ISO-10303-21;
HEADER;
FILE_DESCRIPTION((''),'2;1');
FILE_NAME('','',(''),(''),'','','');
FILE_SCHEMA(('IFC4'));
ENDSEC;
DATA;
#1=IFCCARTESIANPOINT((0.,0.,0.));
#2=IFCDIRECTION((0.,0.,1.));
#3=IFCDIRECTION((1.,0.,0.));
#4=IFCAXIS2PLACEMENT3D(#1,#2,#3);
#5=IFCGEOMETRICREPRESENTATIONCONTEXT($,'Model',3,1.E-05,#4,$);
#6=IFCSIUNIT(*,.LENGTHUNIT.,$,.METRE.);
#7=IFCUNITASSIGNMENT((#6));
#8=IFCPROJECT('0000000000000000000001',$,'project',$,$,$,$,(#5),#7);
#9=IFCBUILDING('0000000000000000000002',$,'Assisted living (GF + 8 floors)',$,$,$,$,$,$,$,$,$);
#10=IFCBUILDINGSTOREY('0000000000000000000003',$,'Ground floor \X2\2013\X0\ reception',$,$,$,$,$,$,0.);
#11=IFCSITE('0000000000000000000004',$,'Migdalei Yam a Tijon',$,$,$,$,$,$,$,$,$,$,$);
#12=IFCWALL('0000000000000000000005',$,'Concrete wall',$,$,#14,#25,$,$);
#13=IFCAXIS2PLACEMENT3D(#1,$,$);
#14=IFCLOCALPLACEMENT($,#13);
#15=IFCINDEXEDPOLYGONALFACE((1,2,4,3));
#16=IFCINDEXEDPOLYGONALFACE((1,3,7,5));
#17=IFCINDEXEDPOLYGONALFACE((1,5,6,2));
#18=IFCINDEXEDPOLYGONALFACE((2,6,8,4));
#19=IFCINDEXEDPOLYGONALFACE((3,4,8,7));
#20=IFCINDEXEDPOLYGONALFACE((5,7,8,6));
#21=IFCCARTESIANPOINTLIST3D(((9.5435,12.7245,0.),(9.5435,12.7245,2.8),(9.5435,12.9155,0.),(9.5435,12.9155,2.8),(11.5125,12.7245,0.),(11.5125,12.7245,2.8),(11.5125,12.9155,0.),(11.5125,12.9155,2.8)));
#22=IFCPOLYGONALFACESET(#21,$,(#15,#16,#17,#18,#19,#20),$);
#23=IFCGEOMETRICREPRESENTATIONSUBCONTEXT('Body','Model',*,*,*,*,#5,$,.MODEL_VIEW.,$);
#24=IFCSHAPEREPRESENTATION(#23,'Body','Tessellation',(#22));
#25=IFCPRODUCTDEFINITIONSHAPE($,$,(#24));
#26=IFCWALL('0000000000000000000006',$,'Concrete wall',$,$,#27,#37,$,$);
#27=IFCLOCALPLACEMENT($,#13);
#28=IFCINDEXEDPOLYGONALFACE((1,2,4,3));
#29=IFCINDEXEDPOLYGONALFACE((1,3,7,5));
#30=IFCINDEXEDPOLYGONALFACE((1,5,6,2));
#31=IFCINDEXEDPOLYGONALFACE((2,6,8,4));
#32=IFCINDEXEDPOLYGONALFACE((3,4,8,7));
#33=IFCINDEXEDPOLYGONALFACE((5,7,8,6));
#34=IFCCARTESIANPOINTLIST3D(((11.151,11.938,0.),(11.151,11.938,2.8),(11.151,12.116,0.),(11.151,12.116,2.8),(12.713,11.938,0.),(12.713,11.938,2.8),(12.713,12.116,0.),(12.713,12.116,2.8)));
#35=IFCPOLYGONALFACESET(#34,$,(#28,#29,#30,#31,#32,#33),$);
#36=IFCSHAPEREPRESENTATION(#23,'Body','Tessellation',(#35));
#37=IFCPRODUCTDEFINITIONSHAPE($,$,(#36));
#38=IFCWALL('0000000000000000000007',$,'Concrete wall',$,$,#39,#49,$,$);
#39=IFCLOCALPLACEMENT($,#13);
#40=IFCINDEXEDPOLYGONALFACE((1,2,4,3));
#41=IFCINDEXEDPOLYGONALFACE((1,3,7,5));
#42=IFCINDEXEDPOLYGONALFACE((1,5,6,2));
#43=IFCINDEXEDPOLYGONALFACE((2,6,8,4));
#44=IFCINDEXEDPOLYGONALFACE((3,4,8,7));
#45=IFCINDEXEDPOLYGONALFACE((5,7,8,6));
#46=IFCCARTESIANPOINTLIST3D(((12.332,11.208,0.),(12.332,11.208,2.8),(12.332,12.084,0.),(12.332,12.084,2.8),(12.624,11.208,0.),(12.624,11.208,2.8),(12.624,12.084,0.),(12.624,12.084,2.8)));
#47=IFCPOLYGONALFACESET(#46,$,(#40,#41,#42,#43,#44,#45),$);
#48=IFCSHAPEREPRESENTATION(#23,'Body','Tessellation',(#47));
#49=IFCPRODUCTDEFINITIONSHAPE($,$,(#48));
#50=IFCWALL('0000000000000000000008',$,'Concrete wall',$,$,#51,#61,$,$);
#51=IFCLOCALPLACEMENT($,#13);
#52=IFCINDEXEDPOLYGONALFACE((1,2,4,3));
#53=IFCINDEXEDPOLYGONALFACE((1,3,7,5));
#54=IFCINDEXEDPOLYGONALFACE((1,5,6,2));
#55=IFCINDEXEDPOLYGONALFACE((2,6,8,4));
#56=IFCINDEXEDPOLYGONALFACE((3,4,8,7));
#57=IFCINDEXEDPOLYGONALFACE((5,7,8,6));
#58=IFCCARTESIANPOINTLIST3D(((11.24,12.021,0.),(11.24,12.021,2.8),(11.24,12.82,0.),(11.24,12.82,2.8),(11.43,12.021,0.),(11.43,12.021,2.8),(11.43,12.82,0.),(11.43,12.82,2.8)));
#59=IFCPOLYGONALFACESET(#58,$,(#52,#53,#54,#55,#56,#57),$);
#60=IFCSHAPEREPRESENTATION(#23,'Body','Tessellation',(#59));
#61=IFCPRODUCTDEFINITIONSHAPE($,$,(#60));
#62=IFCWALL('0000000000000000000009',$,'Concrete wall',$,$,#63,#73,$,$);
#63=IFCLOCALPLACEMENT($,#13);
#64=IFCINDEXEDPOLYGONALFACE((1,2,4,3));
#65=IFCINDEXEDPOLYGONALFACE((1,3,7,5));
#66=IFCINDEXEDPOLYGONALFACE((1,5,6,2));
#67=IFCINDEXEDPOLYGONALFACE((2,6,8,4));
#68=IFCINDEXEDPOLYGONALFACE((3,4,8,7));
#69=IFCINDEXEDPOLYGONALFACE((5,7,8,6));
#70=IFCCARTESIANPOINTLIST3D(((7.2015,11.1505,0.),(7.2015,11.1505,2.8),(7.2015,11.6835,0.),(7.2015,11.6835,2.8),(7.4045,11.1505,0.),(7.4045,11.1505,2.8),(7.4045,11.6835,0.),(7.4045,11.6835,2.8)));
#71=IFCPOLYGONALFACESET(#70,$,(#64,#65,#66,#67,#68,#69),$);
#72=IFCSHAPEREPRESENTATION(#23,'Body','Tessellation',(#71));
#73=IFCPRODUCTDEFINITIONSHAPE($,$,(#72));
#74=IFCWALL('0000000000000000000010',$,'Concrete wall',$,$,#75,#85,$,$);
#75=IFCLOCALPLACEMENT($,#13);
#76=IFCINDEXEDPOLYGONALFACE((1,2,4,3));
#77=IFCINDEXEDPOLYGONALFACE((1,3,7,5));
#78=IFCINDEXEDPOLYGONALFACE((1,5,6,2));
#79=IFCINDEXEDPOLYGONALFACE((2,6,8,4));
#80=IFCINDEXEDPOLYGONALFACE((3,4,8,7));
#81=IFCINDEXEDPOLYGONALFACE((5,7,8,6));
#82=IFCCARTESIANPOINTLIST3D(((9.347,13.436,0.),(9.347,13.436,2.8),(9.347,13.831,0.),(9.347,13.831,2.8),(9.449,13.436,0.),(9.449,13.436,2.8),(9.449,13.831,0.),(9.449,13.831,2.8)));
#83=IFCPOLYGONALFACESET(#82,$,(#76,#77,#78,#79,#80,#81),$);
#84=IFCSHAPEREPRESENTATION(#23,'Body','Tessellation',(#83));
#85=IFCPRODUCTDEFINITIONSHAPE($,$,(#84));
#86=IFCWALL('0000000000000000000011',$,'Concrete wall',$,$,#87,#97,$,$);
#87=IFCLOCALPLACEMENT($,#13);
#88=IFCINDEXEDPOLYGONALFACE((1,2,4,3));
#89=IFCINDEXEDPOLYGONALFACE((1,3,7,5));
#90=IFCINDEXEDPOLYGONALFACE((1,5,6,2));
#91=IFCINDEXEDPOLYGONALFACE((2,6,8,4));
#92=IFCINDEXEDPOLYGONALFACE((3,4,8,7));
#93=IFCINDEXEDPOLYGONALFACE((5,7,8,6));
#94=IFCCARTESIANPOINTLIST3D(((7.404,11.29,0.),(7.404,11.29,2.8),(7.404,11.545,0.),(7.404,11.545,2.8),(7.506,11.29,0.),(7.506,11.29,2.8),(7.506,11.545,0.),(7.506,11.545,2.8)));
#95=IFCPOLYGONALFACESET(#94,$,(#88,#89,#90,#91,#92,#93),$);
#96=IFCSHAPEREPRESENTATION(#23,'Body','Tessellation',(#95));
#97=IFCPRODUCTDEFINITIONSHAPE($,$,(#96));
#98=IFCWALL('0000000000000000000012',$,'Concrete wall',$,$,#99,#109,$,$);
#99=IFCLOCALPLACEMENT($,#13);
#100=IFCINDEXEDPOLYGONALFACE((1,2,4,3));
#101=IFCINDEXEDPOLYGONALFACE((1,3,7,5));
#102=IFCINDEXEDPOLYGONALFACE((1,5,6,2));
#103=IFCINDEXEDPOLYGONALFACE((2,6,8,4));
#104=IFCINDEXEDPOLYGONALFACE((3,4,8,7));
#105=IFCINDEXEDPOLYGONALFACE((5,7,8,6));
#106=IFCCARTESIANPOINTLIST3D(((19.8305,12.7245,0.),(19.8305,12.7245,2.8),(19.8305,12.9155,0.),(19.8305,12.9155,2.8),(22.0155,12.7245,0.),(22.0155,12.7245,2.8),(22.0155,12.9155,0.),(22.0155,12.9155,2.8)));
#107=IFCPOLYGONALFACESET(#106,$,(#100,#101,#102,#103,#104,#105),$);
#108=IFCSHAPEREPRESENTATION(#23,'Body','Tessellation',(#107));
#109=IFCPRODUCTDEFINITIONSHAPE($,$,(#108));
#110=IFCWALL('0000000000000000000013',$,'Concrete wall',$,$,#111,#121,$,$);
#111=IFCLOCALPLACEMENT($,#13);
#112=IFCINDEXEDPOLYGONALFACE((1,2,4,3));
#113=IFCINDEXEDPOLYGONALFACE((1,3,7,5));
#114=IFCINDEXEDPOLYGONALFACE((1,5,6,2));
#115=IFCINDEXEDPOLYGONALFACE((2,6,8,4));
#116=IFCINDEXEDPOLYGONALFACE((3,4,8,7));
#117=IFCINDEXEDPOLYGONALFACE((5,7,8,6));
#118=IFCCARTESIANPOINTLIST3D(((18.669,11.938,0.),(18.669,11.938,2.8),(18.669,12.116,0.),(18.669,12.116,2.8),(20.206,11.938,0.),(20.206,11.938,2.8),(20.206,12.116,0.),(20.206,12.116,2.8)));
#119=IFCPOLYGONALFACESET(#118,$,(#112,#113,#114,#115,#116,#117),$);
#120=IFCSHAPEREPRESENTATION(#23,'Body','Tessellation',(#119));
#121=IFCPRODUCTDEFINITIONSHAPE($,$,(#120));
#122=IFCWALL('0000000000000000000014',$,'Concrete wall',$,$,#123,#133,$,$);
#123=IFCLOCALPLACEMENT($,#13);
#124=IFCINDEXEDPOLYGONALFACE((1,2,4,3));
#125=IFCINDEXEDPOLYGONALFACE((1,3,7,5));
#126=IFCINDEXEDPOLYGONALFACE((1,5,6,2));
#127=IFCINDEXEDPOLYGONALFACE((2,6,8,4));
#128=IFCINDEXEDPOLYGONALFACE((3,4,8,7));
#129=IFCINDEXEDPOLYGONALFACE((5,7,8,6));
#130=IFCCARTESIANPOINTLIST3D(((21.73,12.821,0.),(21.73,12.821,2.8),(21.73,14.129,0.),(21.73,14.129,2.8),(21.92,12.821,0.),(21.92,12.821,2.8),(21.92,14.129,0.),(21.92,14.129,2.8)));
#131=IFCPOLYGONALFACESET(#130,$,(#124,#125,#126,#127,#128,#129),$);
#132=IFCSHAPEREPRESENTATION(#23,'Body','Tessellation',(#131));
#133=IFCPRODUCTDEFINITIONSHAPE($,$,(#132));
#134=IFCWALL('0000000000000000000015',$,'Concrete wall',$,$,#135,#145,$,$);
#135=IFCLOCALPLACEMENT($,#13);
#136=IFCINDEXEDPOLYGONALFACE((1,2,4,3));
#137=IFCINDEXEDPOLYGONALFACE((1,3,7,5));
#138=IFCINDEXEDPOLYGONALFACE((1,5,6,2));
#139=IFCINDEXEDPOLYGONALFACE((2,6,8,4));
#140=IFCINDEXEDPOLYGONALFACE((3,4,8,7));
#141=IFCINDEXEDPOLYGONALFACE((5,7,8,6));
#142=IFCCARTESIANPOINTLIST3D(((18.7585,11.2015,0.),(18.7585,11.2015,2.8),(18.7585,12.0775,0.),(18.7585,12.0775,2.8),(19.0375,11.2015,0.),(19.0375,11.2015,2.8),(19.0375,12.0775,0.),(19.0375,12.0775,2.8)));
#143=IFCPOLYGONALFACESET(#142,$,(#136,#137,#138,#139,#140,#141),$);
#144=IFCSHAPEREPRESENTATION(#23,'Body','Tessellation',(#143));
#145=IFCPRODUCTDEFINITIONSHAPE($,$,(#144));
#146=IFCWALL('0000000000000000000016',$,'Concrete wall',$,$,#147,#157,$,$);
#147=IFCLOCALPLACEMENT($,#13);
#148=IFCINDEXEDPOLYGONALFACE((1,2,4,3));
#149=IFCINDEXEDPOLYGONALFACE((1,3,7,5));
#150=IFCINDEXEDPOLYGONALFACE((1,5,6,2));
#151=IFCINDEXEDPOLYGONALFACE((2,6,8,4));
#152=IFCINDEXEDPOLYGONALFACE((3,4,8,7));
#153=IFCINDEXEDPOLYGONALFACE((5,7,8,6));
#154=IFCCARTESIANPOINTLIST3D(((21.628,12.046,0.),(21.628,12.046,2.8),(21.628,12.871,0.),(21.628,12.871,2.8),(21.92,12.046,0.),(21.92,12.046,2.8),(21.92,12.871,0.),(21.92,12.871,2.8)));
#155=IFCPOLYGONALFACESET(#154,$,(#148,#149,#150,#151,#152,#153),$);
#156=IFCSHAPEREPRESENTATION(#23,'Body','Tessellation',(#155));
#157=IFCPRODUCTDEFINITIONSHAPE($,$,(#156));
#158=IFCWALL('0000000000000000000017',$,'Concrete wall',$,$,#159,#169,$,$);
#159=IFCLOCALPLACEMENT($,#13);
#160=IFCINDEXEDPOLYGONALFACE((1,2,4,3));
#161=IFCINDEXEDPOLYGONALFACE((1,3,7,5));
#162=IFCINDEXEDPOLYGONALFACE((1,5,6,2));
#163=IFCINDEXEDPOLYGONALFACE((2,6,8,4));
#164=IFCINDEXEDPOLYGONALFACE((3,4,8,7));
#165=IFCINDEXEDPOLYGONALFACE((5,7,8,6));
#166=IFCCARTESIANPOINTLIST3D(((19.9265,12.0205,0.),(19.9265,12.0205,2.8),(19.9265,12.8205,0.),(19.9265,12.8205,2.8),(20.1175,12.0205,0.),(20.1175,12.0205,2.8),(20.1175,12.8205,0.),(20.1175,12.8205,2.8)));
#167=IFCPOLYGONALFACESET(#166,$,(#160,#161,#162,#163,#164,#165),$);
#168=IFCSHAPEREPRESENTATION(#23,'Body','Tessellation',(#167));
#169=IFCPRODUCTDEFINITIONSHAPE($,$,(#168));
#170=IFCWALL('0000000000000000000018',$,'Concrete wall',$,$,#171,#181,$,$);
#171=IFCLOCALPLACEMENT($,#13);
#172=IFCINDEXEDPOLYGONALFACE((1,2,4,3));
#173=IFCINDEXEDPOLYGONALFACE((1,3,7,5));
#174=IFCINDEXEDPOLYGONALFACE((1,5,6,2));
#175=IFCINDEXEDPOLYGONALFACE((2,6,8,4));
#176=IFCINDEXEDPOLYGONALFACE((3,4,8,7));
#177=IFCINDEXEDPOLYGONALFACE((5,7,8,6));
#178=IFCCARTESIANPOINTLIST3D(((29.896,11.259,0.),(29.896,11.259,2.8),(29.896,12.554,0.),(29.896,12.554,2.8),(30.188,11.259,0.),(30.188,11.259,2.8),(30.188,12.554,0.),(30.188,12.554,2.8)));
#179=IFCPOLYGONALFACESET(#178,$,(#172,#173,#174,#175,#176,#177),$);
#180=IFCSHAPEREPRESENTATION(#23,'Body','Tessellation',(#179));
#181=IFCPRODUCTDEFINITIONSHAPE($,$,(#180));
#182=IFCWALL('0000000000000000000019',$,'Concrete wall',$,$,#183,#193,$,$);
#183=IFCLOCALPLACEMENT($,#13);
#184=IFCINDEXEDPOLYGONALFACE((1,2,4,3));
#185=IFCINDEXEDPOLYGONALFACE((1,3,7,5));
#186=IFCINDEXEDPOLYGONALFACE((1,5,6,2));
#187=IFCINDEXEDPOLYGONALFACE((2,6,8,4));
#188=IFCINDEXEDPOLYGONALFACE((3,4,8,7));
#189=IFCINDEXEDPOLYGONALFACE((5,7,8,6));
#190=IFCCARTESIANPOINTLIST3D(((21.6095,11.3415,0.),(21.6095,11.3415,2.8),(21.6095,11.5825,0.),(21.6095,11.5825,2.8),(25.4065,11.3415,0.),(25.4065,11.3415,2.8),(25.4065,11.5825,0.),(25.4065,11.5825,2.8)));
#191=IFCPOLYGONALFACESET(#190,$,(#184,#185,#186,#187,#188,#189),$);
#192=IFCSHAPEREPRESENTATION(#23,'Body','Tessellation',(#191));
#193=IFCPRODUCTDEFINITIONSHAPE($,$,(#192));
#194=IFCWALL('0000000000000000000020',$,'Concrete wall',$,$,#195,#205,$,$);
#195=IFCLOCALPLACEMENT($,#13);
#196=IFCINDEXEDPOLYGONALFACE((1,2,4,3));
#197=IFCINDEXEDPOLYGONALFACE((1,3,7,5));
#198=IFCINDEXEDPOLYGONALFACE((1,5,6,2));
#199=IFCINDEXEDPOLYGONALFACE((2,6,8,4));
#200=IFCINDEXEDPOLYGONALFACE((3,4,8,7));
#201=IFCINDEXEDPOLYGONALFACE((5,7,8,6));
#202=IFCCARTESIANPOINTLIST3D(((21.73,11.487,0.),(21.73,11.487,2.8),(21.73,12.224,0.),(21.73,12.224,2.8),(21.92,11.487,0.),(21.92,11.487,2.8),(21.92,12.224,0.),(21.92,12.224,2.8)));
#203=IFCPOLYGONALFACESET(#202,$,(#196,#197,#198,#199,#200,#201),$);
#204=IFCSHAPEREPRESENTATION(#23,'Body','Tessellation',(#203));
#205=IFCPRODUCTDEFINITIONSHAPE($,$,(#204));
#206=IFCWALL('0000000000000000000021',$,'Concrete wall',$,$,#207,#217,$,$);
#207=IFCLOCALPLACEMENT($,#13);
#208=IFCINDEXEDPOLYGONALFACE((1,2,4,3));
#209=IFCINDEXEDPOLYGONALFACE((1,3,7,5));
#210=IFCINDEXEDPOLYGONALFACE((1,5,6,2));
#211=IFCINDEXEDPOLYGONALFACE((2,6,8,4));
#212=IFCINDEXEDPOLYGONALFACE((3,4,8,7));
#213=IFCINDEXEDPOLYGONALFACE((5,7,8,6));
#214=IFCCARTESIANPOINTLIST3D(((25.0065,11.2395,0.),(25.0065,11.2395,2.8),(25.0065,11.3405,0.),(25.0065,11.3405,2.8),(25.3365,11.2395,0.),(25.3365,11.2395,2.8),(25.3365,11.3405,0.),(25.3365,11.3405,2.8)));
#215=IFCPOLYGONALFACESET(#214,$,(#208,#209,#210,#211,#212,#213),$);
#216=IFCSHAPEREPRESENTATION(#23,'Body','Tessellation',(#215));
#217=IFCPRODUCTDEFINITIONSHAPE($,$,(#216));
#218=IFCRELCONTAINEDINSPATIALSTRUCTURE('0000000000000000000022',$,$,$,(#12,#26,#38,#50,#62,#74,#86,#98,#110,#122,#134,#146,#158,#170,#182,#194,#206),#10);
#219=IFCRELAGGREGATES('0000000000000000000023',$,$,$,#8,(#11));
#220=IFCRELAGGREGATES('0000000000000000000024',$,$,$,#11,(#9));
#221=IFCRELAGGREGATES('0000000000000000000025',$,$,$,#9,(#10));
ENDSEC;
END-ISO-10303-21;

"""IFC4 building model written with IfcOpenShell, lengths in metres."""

from ifc_helpers import new_model, si_unit, frame, origin_with_axes, context, subcontext, project, spatial, line, indexed_curve, outline, extrude, element, save


model = new_model("IFC4")

# Units and contexts
model_context = context("Model", 3, precision=1e-05, world=origin_with_axes())
body_context = subcontext(model_context, "Body", "Model", "MODEL_VIEW")
ifc_project = project(units=[si_unit("LENGTHUNIT", "METRE")], contexts=[model_context])

# Site, building, storey
site = spatial("IfcSite", under=ifc_project, Name="Migdalei Yam a Tijon")
building = spatial("IfcBuilding", under=site, Name="Assisted living (GF + 8 floors)")
storey = spatial("IfcBuildingStorey", under=building, Name="Ground floor – reception", Elevation=0.0)

# Walls
element("IfcWall", 1, inside=storey, Name="Concrete wall", context=body_context, shape_type="SweptSolid", body=[
    extrude(outline(indexed_curve([(0.0, 0.0), (1.969, 0.0), (1.969, 0.191), (0.0, 0.191)], segments=[line(1, 2, 3, 4, 1)])), frame((9.5435, 12.7245, 0.0), z_axis=(0.0, 0.0, 1.0), x_axis=(1.0, 0.0, 0.0)), (0.0, 0.0, 1.0), 2.8),
])
element("IfcWall", 2, inside=storey, Name="Concrete wall", context=body_context, shape_type="SweptSolid", body=[
    extrude(outline(indexed_curve([(0.0, 0.0), (1.562, 0.0), (1.562, 0.178), (0.0, 0.178)], segments=[line(1, 2, 3, 4, 1)])), frame((11.151, 11.938, 0.0), z_axis=(0.0, 0.0, 1.0), x_axis=(1.0, 0.0, 0.0)), (0.0, 0.0, 1.0), 2.8),
])
element("IfcWall", 3, inside=storey, Name="Concrete wall", context=body_context, shape_type="SweptSolid", body=[
    extrude(outline(indexed_curve([(0.0, 0.0), (0.292, 0.0), (0.292, 0.876), (0.0, 0.876)], segments=[line(1, 2, 3, 4, 1)])), frame((12.332, 11.208, 0.0), z_axis=(0.0, 0.0, 1.0), x_axis=(1.0, 0.0, 0.0)), (0.0, 0.0, 1.0), 2.8),
])
element("IfcWall", 4, inside=storey, Name="Concrete wall", context=body_context, shape_type="SweptSolid", body=[
    extrude(outline(indexed_curve([(0.0, 0.0), (0.19, 0.0), (0.19, 0.799), (0.0, 0.799)], segments=[line(1, 2, 3, 4, 1)])), frame((11.24, 12.021, 0.0), z_axis=(0.0, 0.0, 1.0), x_axis=(1.0, 0.0, 0.0)), (0.0, 0.0, 1.0), 2.8),
])
element("IfcWall", 5, inside=storey, Name="Concrete wall", context=body_context, shape_type="SweptSolid", body=[
    extrude(outline(indexed_curve([(0.0, 0.0), (0.203, 0.0), (0.203, 0.533), (0.0, 0.533)], segments=[line(1, 2, 3, 4, 1)])), frame((7.2015, 11.1505, 0.0), z_axis=(0.0, 0.0, 1.0), x_axis=(1.0, 0.0, 0.0)), (0.0, 0.0, 1.0), 2.8),
])
element("IfcWall", 6, inside=storey, Name="Concrete wall", context=body_context, shape_type="SweptSolid", body=[
    extrude(outline(indexed_curve([(0.0, 0.0), (0.102, 0.0), (0.102, 0.395), (0.0, 0.395)], segments=[line(1, 2, 3, 4, 1)])), frame((9.347, 13.436, 0.0), z_axis=(0.0, 0.0, 1.0), x_axis=(1.0, 0.0, 0.0)), (0.0, 0.0, 1.0), 2.8),
])
element("IfcWall", 7, inside=storey, Name="Concrete wall", context=body_context, shape_type="SweptSolid", body=[
    extrude(outline(indexed_curve([(0.0, 0.0), (0.102, 0.0), (0.102, 0.255), (0.0, 0.255)], segments=[line(1, 2, 3, 4, 1)])), frame((7.404, 11.29, 0.0), z_axis=(0.0, 0.0, 1.0), x_axis=(1.0, 0.0, 0.0)), (0.0, 0.0, 1.0), 2.8),
])
element("IfcWall", 8, inside=storey, Name="Concrete wall", context=body_context, shape_type="SweptSolid", body=[
    extrude(outline(indexed_curve([(0.0, 0.0), (2.185, 0.0), (2.185, 0.191), (0.0, 0.191)], segments=[line(1, 2, 3, 4, 1)])), frame((19.8305, 12.7245, 0.0), z_axis=(0.0, 0.0, 1.0), x_axis=(1.0, 0.0, 0.0)), (0.0, 0.0, 1.0), 2.8),
])
element("IfcWall", 9, inside=storey, Name="Concrete wall", context=body_context, shape_type="SweptSolid", body=[
    extrude(outline(indexed_curve([(0.0, 0.0), (1.537, 0.0), (1.537, 0.178), (0.0, 0.178)], segments=[line(1, 2, 3, 4, 1)])), frame((18.669, 11.938, 0.0), z_axis=(0.0, 0.0, 1.0), x_axis=(1.0, 0.0, 0.0)), (0.0, 0.0, 1.0), 2.8),
])
element("IfcWall", 10, inside=storey, Name="Concrete wall", context=body_context, shape_type="SweptSolid", body=[
    extrude(outline(indexed_curve([(0.0, 0.0), (0.19, 0.0), (0.19, 1.308), (0.0, 1.308)], segments=[line(1, 2, 3, 4, 1)])), frame((21.73, 12.821, 0.0), z_axis=(0.0, 0.0, 1.0), x_axis=(1.0, 0.0, 0.0)), (0.0, 0.0, 1.0), 2.8),
])
element("IfcWall", 11, inside=storey, Name="Concrete wall", context=body_context, shape_type="SweptSolid", body=[
    extrude(outline(indexed_curve([(0.0, 0.0), (0.279, 0.0), (0.279, 0.876), (0.0, 0.876)], segments=[line(1, 2, 3, 4, 1)])), frame((18.7585, 11.2015, 0.0), z_axis=(0.0, 0.0, 1.0), x_axis=(1.0, 0.0, 0.0)), (0.0, 0.0, 1.0), 2.8),
])
element("IfcWall", 12, inside=storey, Name="Concrete wall", context=body_context, shape_type="SweptSolid", body=[
    extrude(outline(indexed_curve([(0.0, 0.0), (0.292, 0.0), (0.292, 0.825), (0.0, 0.825)], segments=[line(1, 2, 3, 4, 1)])), frame((21.628, 12.046, 0.0), z_axis=(0.0, 0.0, 1.0), x_axis=(1.0, 0.0, 0.0)), (0.0, 0.0, 1.0), 2.8),
])
element("IfcWall", 13, inside=storey, Name="Concrete wall", context=body_context, shape_type="SweptSolid", body=[
    extrude(outline(indexed_curve([(0.0, 0.0), (0.191, 0.0), (0.191, 0.8), (0.0, 0.8)], segments=[line(1, 2, 3, 4, 1)])), frame((19.9265, 12.0205, 0.0), z_axis=(0.0, 0.0, 1.0), x_axis=(1.0, 0.0, 0.0)), (0.0, 0.0, 1.0), 2.8),
])
element("IfcWall", 14, inside=storey, Name="Concrete wall", context=body_context, shape_type="SweptSolid", body=[
    extrude(outline(indexed_curve([(0.0, 0.0), (0.292, 0.0), (0.292, 1.295), (0.0, 1.295)], segments=[line(1, 2, 3, 4, 1)])), frame((29.896, 11.259, 0.0), z_axis=(0.0, 0.0, 1.0), x_axis=(1.0, 0.0, 0.0)), (0.0, 0.0, 1.0), 2.8),
])
element("IfcWall", 15, inside=storey, Name="Concrete wall", context=body_context, shape_type="SweptSolid", body=[
    extrude(outline(indexed_curve([(0.0, 0.0), (3.797, 0.0), (3.797, 0.241), (0.0, 0.241)], segments=[line(1, 2, 3, 4, 1)])), frame((21.6095, 11.3415, 0.0), z_axis=(0.0, 0.0, 1.0), x_axis=(1.0, 0.0, 0.0)), (0.0, 0.0, 1.0), 2.8),
])
element("IfcWall", 16, inside=storey, Name="Concrete wall", context=body_context, shape_type="SweptSolid", body=[
    extrude(outline(indexed_curve([(0.0, 0.0), (0.19, 0.0), (0.19, 0.737), (0.0, 0.737)], segments=[line(1, 2, 3, 4, 1)])), frame((21.73, 11.487, 0.0), z_axis=(0.0, 0.0, 1.0), x_axis=(1.0, 0.0, 0.0)), (0.0, 0.0, 1.0), 2.8),
])
element("IfcWall", 17, inside=storey, Name="Concrete wall", context=body_context, shape_type="SweptSolid", body=[
    extrude(outline(indexed_curve([(0.0, 0.0), (0.33, 0.0), (0.33, 0.101), (0.0, 0.101)], segments=[line(1, 2, 3, 4, 1)])), frame((25.0065, 11.2395, 0.0), z_axis=(0.0, 0.0, 1.0), x_axis=(1.0, 0.0, 0.0)), (0.0, 0.0, 1.0), 2.8),
])

save(model, "model.ifc")
